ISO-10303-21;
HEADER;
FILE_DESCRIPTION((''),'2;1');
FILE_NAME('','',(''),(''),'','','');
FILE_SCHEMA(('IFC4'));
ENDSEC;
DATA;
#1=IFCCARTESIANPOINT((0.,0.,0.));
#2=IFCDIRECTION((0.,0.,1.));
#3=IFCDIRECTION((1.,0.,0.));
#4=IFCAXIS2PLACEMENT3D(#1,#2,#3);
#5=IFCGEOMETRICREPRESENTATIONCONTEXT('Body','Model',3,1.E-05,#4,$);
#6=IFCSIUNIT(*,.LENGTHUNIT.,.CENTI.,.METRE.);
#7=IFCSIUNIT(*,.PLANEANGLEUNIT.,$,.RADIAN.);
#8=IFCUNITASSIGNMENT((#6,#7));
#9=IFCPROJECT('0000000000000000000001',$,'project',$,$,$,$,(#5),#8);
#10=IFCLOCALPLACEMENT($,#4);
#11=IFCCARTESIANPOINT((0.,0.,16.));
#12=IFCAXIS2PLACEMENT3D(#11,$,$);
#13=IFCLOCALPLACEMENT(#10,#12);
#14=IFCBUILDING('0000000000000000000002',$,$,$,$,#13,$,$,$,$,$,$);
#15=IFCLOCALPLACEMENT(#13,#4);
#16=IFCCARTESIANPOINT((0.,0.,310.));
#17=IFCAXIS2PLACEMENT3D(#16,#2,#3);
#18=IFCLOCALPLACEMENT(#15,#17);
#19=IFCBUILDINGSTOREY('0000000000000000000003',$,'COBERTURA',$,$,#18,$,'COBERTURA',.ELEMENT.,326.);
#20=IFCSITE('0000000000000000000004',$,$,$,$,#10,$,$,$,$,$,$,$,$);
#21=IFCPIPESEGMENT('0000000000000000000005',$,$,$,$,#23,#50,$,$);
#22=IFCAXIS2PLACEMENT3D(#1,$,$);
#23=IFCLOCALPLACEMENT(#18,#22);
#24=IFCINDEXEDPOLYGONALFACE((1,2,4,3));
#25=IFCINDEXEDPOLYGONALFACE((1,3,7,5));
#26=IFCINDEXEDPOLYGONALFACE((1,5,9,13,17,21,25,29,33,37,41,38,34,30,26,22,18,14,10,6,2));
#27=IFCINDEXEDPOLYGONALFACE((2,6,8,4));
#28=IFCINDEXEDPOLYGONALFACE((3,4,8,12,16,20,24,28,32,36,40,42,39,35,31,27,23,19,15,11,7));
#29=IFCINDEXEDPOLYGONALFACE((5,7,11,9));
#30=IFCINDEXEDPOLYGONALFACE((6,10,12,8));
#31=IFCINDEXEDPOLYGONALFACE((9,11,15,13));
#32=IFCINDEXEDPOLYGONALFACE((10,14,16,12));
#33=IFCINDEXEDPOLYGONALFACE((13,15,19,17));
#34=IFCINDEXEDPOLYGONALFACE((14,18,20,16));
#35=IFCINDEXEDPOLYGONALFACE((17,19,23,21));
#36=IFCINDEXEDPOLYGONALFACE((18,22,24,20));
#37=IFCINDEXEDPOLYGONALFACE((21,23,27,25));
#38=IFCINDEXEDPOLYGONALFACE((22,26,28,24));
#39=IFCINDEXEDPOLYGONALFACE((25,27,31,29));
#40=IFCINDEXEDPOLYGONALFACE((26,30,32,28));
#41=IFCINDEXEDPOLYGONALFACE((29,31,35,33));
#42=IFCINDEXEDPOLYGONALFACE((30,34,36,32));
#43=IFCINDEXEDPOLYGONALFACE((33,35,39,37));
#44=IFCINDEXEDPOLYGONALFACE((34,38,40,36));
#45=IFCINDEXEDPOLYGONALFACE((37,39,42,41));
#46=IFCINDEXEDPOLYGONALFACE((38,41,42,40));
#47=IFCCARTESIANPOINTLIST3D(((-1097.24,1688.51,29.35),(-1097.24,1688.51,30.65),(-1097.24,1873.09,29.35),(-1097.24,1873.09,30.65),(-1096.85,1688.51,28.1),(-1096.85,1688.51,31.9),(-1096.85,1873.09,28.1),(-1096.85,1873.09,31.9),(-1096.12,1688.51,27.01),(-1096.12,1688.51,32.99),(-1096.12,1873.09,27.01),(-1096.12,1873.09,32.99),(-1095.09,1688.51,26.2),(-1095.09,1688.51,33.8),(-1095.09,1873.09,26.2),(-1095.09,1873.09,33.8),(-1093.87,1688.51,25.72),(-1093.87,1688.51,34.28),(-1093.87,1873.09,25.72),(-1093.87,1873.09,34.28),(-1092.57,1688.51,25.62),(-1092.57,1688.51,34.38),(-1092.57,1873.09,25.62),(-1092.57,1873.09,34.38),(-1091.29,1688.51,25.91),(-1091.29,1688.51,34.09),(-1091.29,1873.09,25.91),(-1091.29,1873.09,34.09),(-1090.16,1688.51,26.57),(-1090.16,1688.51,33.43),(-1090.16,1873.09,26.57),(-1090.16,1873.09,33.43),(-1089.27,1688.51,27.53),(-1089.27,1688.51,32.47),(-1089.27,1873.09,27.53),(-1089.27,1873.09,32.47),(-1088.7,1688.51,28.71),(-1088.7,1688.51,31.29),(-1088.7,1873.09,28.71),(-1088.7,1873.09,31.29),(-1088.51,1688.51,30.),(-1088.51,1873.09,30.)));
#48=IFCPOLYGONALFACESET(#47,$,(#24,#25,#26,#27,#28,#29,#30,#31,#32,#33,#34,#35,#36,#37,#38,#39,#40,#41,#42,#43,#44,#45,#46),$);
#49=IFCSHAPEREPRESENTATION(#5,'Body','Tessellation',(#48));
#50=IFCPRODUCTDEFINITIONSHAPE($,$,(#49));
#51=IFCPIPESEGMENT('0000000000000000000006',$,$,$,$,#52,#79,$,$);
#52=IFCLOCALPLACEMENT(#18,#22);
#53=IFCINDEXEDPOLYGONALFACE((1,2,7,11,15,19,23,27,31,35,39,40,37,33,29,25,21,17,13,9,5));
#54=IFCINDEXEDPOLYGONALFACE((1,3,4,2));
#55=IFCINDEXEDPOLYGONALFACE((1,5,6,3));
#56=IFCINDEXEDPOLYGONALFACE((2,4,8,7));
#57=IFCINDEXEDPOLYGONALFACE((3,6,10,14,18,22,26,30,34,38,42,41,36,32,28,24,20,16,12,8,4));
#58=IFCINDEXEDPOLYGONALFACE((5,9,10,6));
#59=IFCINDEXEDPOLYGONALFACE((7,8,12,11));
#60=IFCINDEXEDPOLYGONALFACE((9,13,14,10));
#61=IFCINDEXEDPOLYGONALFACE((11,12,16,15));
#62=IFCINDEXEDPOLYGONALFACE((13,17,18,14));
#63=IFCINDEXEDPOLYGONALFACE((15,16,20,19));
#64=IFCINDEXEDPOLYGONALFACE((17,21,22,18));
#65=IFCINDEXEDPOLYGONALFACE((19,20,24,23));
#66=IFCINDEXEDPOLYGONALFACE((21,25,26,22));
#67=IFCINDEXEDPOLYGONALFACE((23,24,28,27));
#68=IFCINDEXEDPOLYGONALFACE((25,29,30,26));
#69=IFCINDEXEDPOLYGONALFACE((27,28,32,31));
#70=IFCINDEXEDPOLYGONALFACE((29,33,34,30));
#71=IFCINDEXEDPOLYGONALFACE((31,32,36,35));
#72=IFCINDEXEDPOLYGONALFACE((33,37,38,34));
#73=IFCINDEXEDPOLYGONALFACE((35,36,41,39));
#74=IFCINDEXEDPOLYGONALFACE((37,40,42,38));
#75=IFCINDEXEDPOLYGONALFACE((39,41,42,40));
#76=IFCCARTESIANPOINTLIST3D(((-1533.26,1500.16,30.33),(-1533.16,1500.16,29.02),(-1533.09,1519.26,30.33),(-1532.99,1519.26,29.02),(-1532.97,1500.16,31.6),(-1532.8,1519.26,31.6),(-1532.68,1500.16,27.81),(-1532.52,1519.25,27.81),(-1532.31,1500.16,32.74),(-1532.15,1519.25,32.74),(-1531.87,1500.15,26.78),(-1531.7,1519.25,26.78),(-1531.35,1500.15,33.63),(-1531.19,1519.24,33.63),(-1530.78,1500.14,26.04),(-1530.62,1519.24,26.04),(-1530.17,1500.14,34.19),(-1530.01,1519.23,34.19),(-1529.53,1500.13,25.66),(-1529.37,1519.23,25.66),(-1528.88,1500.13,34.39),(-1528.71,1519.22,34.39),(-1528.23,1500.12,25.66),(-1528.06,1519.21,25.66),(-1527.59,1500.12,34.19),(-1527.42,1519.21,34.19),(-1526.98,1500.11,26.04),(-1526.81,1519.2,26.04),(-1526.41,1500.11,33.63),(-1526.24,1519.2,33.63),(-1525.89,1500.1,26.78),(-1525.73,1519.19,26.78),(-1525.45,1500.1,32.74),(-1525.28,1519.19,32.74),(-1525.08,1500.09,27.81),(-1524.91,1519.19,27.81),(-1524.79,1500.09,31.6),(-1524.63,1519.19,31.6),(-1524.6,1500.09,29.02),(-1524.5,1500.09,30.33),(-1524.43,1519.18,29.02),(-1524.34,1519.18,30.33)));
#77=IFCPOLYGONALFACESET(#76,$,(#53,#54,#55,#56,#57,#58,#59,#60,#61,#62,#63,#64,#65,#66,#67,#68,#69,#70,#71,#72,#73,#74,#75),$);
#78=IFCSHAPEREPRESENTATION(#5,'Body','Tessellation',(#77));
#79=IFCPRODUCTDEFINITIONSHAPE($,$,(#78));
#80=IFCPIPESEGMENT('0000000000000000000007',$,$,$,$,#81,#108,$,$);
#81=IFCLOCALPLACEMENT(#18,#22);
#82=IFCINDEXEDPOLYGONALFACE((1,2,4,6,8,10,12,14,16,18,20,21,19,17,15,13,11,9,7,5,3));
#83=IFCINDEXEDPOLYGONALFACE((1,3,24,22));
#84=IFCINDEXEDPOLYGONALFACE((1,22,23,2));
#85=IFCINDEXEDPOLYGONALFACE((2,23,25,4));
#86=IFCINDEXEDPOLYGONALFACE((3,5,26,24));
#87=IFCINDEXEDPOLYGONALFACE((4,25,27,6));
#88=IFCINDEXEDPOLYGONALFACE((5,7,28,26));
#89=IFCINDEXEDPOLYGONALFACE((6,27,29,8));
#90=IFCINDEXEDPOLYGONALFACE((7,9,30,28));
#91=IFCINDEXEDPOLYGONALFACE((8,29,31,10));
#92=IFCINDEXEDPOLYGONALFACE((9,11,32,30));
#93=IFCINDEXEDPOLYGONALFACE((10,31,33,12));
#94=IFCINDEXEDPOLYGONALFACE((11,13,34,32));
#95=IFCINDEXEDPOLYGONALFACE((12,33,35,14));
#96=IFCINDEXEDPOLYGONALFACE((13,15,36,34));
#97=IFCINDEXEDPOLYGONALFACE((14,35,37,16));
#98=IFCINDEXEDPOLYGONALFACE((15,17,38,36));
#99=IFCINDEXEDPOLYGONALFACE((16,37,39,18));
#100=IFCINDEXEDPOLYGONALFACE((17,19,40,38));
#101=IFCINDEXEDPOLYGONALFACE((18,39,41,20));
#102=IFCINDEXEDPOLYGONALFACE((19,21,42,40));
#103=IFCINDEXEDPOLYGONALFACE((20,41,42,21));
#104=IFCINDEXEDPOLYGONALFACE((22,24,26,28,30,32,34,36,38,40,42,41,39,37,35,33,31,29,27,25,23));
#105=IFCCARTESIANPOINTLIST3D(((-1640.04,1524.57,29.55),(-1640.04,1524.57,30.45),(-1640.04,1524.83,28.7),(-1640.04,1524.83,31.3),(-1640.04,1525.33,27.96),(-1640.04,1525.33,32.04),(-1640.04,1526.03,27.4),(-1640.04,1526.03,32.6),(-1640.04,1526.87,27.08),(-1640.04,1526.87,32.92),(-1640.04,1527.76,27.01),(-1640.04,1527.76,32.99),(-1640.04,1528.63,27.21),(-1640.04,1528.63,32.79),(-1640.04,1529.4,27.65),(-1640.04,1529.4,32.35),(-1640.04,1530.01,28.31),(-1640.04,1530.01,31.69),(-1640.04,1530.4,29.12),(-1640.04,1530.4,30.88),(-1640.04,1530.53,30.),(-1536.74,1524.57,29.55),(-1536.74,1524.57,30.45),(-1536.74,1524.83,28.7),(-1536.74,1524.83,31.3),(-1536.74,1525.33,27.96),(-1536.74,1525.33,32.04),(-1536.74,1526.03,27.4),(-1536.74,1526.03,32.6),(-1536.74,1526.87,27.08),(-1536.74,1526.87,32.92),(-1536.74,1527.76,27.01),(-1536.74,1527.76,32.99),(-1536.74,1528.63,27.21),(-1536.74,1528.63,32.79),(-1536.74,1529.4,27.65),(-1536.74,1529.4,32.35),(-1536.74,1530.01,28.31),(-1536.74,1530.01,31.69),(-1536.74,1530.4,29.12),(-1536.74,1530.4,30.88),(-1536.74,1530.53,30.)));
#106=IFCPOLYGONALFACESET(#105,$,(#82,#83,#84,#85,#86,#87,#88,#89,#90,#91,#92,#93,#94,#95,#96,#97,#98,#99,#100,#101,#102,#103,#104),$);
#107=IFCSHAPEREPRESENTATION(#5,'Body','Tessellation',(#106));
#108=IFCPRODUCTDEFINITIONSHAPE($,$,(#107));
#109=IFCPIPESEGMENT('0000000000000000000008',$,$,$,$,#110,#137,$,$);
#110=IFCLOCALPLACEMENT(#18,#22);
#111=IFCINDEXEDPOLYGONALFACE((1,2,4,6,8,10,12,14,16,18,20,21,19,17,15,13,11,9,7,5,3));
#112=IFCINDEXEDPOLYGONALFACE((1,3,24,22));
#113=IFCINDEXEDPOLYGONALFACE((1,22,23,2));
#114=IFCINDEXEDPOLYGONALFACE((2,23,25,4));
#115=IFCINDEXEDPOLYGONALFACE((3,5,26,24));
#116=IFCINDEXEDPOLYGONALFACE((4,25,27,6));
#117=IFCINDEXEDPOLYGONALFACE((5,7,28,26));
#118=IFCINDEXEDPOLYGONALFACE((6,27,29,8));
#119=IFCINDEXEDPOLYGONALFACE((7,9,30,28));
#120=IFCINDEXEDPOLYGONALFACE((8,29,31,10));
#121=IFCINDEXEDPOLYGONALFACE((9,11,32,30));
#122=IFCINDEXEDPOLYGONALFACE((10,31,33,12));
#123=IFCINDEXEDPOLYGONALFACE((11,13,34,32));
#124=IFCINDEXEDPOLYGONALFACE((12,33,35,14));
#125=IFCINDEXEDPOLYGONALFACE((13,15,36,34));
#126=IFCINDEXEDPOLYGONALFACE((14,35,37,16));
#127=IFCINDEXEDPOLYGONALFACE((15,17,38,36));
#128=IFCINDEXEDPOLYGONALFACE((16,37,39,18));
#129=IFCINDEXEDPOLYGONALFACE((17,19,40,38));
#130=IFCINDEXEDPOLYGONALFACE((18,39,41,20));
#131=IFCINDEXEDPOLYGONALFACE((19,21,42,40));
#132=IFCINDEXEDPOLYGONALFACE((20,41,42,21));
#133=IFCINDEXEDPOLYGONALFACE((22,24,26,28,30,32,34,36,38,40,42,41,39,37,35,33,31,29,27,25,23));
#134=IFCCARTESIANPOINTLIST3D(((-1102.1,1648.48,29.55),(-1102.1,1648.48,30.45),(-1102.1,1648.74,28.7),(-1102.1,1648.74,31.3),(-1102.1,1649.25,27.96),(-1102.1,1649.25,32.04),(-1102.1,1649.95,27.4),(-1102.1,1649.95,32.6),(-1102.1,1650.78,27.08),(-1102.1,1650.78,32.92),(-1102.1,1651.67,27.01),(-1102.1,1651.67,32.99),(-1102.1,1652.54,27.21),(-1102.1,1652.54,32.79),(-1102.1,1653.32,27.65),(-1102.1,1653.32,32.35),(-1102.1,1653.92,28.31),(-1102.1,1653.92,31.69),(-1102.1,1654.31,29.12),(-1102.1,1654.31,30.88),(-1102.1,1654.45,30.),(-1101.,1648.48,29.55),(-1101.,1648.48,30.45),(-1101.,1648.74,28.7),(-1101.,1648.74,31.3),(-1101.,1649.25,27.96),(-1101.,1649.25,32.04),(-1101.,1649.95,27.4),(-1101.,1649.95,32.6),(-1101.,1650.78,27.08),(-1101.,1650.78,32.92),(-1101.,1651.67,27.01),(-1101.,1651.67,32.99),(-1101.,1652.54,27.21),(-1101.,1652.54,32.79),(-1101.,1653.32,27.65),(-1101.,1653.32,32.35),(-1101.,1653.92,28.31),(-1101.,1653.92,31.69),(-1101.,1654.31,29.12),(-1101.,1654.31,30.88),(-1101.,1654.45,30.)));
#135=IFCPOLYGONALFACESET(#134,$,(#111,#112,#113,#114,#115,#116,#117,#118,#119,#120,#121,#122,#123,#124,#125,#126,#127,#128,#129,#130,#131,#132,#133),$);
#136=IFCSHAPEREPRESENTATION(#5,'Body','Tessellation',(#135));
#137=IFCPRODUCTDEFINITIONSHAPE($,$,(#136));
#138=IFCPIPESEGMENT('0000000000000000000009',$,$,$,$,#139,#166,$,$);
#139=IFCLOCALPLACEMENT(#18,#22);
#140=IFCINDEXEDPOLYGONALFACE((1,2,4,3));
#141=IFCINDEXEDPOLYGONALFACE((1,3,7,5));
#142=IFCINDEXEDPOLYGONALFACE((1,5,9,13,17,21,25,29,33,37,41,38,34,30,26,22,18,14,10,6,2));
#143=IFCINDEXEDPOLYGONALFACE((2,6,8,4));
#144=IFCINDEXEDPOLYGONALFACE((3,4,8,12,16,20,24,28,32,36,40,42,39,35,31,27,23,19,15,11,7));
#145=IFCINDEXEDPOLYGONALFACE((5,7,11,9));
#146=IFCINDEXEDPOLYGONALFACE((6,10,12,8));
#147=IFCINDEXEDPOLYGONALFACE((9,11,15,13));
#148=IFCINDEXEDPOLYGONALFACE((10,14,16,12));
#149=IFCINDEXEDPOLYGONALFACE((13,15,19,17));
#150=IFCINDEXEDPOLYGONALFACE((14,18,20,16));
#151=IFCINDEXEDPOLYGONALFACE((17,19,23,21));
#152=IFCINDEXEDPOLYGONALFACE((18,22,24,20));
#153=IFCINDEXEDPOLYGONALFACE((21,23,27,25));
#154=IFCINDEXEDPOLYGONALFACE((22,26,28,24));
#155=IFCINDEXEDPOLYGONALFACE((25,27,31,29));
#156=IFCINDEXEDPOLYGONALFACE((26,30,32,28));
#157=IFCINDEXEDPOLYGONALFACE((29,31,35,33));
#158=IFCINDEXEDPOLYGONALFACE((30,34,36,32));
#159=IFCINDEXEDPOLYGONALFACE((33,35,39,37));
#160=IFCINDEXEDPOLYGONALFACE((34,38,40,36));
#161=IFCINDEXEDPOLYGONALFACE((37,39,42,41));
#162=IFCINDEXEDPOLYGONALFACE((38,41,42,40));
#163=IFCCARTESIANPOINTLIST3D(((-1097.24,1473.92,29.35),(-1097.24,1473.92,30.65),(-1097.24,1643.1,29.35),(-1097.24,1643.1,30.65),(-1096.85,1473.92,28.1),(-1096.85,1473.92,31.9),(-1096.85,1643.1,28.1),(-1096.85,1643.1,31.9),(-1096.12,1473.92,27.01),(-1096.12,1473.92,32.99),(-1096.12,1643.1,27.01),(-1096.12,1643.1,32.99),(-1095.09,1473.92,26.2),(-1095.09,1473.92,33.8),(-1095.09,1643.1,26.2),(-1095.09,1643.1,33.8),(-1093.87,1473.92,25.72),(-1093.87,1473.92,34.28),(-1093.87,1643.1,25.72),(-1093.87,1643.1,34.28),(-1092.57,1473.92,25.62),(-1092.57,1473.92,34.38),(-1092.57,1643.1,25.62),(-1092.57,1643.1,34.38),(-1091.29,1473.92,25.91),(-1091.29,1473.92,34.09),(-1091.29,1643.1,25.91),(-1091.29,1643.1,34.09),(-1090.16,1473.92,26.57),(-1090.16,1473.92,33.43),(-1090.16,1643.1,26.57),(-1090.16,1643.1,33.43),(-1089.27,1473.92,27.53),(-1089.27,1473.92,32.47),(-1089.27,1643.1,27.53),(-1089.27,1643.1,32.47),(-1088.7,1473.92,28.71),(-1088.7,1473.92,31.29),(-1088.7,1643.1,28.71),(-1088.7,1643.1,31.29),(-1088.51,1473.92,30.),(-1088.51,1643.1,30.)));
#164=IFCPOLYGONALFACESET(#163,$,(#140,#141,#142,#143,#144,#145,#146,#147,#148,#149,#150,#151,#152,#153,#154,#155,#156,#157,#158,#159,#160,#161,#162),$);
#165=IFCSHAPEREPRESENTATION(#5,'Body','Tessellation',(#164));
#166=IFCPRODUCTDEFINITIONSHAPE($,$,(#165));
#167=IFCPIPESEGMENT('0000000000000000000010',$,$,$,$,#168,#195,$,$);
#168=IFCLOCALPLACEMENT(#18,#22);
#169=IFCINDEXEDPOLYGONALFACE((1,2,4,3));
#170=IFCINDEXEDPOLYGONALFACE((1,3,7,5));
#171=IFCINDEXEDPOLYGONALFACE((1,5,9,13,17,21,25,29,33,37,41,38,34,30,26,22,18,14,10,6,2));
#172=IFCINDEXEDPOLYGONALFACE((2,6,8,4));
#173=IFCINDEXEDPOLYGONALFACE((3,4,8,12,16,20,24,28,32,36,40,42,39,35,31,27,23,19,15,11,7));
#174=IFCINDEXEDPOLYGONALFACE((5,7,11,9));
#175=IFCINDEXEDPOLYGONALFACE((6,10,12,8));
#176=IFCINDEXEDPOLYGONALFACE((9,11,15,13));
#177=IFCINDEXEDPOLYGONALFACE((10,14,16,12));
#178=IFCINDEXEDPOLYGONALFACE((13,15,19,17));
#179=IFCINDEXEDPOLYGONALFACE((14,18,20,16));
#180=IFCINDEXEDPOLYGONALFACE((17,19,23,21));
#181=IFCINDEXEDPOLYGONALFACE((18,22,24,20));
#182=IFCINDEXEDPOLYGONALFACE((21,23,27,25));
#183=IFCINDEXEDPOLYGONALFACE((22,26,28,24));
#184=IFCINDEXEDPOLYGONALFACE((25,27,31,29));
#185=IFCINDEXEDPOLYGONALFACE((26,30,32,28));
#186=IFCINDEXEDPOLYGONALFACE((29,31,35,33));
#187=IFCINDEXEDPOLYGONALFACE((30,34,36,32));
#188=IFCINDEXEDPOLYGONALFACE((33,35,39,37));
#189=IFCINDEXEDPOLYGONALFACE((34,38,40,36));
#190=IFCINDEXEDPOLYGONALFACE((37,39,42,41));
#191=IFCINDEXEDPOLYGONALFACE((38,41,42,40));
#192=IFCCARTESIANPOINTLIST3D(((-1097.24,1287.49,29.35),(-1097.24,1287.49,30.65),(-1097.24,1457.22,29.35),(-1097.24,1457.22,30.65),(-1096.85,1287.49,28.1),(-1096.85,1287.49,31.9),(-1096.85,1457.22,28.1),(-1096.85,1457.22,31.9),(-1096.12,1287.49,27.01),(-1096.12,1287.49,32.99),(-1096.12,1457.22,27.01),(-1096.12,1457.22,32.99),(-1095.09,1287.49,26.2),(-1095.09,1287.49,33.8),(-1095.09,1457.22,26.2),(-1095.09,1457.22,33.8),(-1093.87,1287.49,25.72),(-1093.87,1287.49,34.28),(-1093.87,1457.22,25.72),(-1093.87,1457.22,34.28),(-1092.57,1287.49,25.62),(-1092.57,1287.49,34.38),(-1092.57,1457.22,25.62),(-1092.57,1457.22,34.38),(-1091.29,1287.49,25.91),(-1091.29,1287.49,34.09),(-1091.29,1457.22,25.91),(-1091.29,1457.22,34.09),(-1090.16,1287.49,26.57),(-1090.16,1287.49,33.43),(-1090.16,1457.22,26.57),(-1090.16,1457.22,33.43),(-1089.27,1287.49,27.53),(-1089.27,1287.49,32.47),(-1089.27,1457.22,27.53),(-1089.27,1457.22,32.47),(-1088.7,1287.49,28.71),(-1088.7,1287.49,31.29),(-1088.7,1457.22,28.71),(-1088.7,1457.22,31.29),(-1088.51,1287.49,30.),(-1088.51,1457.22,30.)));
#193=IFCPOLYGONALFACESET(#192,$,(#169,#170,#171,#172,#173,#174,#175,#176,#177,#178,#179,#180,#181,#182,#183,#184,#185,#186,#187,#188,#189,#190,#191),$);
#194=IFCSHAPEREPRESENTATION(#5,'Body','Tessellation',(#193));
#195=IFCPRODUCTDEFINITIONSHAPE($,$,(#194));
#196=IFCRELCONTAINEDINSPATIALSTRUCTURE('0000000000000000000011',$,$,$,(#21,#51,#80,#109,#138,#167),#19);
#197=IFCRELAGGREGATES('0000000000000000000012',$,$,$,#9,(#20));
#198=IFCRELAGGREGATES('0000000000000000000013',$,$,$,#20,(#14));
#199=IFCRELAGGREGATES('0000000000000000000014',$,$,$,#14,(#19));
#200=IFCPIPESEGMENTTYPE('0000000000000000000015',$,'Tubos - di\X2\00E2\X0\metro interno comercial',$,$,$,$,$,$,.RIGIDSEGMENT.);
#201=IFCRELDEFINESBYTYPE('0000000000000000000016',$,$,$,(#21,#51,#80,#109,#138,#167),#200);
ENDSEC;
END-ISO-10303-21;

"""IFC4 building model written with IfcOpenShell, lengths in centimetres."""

from ifc_helpers import new_model, si_unit, frame, origin_with_axes, origin_2d_with_axis, place, context, project, spatial, circle, extrude, type_object, element, save


model = new_model("IFC4")

# Units and contexts
model_context = context("Model", 3, precision=1e-05, world=origin_with_axes(), identifier="Body")
ifc_project = project(units=[si_unit("LENGTHUNIT", "METRE", prefix="CENTI"), si_unit("PLANEANGLEUNIT", "RADIAN")], contexts=[model_context])

# Site, building, storey
site_placement = place(None, origin_with_axes())
site = spatial("IfcSite", under=ifc_project, at=site_placement)
building_placement = place(site_placement, frame((0.0, 0.0, 16.0)))
building = spatial("IfcBuilding", under=site, at=building_placement)
placement = place(building_placement, origin_with_axes())
storey_placement = place(placement, frame((0.0, 0.0, 310.0), z_axis=(0.0, 0.0, 1.0), x_axis=(1.0, 0.0, 0.0)))
storey = spatial("IfcBuildingStorey", under=building, at=storey_placement, Name="COBERTURA", LongName="COBERTURA", CompositionType="ELEMENT", Elevation=326.0)

# Pipe segments
pipe_segment_type = type_object("IfcPipeSegmentType", Name="Tubos - diâmetro interno comercial", PredefinedType="RIGIDSEGMENT")
pipe_segment_1_placement = place(storey_placement, frame((-1092.9, 1780.8, 34.39), z_axis=(0.0, 0.0, 1.0), x_axis=(1.0, 0.0, 0.0)))
element("IfcPipeSegment", 1, at=pipe_segment_1_placement, inside=storey, type_object=pipe_segment_type, context=model_context, shape_type="SolidModel", body=[
    extrude(circle(Radius=4.39, at=origin_2d_with_axis()), frame((0.0, 92.29, -4.39), z_axis=(0.0, -1.0, 0.0), x_axis=(1.0, 0.0, 0.0)), (0.0, 0.0, 1.0), 184.58),
])
pipe_segment_2_placement = place(storey_placement, frame((-1528.8, 1509.67, 34.39), z_axis=(0.0, 0.0, 1.0), x_axis=(1.0, 0.0, 0.0)))
element("IfcPipeSegment", 2, at=pipe_segment_2_placement, inside=storey, type_object=pipe_segment_type, context=model_context, shape_type="SolidModel", body=[
    extrude(circle(Radius=4.39, at=origin_2d_with_axis()), frame((0.08, 9.55, -4.39), z_axis=(-0.008652, -1.0, 0.0), x_axis=(0.0, 0.0, 1.0)), (0.0, 0.0, 1.0), 19.09),
])
pipe_segment_3_placement = place(storey_placement, frame((-1588.39, 1527.53, 33.0), z_axis=(0.0, 0.0, 1.0), x_axis=(1.0, 0.0, 0.0)))
element("IfcPipeSegment", 3, at=pipe_segment_3_placement, inside=storey, type_object=pipe_segment_type, context=model_context, shape_type="SolidModel", body=[
    extrude(circle(Radius=3.0, at=origin_2d_with_axis()), frame((51.65, 0.0, -3.0), z_axis=(-1.0, 0.0, 0.0), x_axis=(0.0, 1.0, 0.0)), (0.0, 0.0, 1.0), 103.3),
])
pipe_segment_4_placement = place(storey_placement, frame((-1101.55, 1651.45, 33.0), z_axis=(0.0, 0.0, 1.0), x_axis=(1.0, 0.0, 0.0)))
element("IfcPipeSegment", 4, at=pipe_segment_4_placement, inside=storey, type_object=pipe_segment_type, context=model_context, shape_type="SolidModel", body=[
    extrude(circle(Radius=3.0, at=origin_2d_with_axis()), frame((0.55, 0.0, -3.0), z_axis=(-1.0, 0.0, 0.0), x_axis=(0.0, 1.0, 0.0)), (0.0, 0.0, 1.0), 1.1),
])
pipe_segment_5_placement = place(storey_placement, frame((-1092.9, 1558.51, 34.39), z_axis=(0.0, 0.0, 1.0), x_axis=(1.0, 0.0, 0.0)))
element("IfcPipeSegment", 5, at=pipe_segment_5_placement, inside=storey, type_object=pipe_segment_type, context=model_context, shape_type="SolidModel", body=[
    extrude(circle(Radius=4.39, at=origin_2d_with_axis()), frame((0.0, 84.59, -4.39), z_axis=(0.0, -1.0, 0.0), x_axis=(1.0, 0.0, 0.0)), (0.0, 0.0, 1.0), 169.17),
])
pipe_segment_6_placement = place(storey_placement, frame((-1092.9, 1372.36, 34.39), z_axis=(0.0, 0.0, 1.0), x_axis=(1.0, 0.0, 0.0)))
element("IfcPipeSegment", 6, at=pipe_segment_6_placement, inside=storey, type_object=pipe_segment_type, context=model_context, shape_type="SolidModel", body=[
    extrude(circle(Radius=4.39, at=origin_2d_with_axis()), frame((0.0, 84.87, -4.39), z_axis=(0.0, -1.0, 0.0), x_axis=(1.0, 0.0, 0.0)), (0.0, 0.0, 1.0), 169.73),
])

save(model, "model.ifc")
